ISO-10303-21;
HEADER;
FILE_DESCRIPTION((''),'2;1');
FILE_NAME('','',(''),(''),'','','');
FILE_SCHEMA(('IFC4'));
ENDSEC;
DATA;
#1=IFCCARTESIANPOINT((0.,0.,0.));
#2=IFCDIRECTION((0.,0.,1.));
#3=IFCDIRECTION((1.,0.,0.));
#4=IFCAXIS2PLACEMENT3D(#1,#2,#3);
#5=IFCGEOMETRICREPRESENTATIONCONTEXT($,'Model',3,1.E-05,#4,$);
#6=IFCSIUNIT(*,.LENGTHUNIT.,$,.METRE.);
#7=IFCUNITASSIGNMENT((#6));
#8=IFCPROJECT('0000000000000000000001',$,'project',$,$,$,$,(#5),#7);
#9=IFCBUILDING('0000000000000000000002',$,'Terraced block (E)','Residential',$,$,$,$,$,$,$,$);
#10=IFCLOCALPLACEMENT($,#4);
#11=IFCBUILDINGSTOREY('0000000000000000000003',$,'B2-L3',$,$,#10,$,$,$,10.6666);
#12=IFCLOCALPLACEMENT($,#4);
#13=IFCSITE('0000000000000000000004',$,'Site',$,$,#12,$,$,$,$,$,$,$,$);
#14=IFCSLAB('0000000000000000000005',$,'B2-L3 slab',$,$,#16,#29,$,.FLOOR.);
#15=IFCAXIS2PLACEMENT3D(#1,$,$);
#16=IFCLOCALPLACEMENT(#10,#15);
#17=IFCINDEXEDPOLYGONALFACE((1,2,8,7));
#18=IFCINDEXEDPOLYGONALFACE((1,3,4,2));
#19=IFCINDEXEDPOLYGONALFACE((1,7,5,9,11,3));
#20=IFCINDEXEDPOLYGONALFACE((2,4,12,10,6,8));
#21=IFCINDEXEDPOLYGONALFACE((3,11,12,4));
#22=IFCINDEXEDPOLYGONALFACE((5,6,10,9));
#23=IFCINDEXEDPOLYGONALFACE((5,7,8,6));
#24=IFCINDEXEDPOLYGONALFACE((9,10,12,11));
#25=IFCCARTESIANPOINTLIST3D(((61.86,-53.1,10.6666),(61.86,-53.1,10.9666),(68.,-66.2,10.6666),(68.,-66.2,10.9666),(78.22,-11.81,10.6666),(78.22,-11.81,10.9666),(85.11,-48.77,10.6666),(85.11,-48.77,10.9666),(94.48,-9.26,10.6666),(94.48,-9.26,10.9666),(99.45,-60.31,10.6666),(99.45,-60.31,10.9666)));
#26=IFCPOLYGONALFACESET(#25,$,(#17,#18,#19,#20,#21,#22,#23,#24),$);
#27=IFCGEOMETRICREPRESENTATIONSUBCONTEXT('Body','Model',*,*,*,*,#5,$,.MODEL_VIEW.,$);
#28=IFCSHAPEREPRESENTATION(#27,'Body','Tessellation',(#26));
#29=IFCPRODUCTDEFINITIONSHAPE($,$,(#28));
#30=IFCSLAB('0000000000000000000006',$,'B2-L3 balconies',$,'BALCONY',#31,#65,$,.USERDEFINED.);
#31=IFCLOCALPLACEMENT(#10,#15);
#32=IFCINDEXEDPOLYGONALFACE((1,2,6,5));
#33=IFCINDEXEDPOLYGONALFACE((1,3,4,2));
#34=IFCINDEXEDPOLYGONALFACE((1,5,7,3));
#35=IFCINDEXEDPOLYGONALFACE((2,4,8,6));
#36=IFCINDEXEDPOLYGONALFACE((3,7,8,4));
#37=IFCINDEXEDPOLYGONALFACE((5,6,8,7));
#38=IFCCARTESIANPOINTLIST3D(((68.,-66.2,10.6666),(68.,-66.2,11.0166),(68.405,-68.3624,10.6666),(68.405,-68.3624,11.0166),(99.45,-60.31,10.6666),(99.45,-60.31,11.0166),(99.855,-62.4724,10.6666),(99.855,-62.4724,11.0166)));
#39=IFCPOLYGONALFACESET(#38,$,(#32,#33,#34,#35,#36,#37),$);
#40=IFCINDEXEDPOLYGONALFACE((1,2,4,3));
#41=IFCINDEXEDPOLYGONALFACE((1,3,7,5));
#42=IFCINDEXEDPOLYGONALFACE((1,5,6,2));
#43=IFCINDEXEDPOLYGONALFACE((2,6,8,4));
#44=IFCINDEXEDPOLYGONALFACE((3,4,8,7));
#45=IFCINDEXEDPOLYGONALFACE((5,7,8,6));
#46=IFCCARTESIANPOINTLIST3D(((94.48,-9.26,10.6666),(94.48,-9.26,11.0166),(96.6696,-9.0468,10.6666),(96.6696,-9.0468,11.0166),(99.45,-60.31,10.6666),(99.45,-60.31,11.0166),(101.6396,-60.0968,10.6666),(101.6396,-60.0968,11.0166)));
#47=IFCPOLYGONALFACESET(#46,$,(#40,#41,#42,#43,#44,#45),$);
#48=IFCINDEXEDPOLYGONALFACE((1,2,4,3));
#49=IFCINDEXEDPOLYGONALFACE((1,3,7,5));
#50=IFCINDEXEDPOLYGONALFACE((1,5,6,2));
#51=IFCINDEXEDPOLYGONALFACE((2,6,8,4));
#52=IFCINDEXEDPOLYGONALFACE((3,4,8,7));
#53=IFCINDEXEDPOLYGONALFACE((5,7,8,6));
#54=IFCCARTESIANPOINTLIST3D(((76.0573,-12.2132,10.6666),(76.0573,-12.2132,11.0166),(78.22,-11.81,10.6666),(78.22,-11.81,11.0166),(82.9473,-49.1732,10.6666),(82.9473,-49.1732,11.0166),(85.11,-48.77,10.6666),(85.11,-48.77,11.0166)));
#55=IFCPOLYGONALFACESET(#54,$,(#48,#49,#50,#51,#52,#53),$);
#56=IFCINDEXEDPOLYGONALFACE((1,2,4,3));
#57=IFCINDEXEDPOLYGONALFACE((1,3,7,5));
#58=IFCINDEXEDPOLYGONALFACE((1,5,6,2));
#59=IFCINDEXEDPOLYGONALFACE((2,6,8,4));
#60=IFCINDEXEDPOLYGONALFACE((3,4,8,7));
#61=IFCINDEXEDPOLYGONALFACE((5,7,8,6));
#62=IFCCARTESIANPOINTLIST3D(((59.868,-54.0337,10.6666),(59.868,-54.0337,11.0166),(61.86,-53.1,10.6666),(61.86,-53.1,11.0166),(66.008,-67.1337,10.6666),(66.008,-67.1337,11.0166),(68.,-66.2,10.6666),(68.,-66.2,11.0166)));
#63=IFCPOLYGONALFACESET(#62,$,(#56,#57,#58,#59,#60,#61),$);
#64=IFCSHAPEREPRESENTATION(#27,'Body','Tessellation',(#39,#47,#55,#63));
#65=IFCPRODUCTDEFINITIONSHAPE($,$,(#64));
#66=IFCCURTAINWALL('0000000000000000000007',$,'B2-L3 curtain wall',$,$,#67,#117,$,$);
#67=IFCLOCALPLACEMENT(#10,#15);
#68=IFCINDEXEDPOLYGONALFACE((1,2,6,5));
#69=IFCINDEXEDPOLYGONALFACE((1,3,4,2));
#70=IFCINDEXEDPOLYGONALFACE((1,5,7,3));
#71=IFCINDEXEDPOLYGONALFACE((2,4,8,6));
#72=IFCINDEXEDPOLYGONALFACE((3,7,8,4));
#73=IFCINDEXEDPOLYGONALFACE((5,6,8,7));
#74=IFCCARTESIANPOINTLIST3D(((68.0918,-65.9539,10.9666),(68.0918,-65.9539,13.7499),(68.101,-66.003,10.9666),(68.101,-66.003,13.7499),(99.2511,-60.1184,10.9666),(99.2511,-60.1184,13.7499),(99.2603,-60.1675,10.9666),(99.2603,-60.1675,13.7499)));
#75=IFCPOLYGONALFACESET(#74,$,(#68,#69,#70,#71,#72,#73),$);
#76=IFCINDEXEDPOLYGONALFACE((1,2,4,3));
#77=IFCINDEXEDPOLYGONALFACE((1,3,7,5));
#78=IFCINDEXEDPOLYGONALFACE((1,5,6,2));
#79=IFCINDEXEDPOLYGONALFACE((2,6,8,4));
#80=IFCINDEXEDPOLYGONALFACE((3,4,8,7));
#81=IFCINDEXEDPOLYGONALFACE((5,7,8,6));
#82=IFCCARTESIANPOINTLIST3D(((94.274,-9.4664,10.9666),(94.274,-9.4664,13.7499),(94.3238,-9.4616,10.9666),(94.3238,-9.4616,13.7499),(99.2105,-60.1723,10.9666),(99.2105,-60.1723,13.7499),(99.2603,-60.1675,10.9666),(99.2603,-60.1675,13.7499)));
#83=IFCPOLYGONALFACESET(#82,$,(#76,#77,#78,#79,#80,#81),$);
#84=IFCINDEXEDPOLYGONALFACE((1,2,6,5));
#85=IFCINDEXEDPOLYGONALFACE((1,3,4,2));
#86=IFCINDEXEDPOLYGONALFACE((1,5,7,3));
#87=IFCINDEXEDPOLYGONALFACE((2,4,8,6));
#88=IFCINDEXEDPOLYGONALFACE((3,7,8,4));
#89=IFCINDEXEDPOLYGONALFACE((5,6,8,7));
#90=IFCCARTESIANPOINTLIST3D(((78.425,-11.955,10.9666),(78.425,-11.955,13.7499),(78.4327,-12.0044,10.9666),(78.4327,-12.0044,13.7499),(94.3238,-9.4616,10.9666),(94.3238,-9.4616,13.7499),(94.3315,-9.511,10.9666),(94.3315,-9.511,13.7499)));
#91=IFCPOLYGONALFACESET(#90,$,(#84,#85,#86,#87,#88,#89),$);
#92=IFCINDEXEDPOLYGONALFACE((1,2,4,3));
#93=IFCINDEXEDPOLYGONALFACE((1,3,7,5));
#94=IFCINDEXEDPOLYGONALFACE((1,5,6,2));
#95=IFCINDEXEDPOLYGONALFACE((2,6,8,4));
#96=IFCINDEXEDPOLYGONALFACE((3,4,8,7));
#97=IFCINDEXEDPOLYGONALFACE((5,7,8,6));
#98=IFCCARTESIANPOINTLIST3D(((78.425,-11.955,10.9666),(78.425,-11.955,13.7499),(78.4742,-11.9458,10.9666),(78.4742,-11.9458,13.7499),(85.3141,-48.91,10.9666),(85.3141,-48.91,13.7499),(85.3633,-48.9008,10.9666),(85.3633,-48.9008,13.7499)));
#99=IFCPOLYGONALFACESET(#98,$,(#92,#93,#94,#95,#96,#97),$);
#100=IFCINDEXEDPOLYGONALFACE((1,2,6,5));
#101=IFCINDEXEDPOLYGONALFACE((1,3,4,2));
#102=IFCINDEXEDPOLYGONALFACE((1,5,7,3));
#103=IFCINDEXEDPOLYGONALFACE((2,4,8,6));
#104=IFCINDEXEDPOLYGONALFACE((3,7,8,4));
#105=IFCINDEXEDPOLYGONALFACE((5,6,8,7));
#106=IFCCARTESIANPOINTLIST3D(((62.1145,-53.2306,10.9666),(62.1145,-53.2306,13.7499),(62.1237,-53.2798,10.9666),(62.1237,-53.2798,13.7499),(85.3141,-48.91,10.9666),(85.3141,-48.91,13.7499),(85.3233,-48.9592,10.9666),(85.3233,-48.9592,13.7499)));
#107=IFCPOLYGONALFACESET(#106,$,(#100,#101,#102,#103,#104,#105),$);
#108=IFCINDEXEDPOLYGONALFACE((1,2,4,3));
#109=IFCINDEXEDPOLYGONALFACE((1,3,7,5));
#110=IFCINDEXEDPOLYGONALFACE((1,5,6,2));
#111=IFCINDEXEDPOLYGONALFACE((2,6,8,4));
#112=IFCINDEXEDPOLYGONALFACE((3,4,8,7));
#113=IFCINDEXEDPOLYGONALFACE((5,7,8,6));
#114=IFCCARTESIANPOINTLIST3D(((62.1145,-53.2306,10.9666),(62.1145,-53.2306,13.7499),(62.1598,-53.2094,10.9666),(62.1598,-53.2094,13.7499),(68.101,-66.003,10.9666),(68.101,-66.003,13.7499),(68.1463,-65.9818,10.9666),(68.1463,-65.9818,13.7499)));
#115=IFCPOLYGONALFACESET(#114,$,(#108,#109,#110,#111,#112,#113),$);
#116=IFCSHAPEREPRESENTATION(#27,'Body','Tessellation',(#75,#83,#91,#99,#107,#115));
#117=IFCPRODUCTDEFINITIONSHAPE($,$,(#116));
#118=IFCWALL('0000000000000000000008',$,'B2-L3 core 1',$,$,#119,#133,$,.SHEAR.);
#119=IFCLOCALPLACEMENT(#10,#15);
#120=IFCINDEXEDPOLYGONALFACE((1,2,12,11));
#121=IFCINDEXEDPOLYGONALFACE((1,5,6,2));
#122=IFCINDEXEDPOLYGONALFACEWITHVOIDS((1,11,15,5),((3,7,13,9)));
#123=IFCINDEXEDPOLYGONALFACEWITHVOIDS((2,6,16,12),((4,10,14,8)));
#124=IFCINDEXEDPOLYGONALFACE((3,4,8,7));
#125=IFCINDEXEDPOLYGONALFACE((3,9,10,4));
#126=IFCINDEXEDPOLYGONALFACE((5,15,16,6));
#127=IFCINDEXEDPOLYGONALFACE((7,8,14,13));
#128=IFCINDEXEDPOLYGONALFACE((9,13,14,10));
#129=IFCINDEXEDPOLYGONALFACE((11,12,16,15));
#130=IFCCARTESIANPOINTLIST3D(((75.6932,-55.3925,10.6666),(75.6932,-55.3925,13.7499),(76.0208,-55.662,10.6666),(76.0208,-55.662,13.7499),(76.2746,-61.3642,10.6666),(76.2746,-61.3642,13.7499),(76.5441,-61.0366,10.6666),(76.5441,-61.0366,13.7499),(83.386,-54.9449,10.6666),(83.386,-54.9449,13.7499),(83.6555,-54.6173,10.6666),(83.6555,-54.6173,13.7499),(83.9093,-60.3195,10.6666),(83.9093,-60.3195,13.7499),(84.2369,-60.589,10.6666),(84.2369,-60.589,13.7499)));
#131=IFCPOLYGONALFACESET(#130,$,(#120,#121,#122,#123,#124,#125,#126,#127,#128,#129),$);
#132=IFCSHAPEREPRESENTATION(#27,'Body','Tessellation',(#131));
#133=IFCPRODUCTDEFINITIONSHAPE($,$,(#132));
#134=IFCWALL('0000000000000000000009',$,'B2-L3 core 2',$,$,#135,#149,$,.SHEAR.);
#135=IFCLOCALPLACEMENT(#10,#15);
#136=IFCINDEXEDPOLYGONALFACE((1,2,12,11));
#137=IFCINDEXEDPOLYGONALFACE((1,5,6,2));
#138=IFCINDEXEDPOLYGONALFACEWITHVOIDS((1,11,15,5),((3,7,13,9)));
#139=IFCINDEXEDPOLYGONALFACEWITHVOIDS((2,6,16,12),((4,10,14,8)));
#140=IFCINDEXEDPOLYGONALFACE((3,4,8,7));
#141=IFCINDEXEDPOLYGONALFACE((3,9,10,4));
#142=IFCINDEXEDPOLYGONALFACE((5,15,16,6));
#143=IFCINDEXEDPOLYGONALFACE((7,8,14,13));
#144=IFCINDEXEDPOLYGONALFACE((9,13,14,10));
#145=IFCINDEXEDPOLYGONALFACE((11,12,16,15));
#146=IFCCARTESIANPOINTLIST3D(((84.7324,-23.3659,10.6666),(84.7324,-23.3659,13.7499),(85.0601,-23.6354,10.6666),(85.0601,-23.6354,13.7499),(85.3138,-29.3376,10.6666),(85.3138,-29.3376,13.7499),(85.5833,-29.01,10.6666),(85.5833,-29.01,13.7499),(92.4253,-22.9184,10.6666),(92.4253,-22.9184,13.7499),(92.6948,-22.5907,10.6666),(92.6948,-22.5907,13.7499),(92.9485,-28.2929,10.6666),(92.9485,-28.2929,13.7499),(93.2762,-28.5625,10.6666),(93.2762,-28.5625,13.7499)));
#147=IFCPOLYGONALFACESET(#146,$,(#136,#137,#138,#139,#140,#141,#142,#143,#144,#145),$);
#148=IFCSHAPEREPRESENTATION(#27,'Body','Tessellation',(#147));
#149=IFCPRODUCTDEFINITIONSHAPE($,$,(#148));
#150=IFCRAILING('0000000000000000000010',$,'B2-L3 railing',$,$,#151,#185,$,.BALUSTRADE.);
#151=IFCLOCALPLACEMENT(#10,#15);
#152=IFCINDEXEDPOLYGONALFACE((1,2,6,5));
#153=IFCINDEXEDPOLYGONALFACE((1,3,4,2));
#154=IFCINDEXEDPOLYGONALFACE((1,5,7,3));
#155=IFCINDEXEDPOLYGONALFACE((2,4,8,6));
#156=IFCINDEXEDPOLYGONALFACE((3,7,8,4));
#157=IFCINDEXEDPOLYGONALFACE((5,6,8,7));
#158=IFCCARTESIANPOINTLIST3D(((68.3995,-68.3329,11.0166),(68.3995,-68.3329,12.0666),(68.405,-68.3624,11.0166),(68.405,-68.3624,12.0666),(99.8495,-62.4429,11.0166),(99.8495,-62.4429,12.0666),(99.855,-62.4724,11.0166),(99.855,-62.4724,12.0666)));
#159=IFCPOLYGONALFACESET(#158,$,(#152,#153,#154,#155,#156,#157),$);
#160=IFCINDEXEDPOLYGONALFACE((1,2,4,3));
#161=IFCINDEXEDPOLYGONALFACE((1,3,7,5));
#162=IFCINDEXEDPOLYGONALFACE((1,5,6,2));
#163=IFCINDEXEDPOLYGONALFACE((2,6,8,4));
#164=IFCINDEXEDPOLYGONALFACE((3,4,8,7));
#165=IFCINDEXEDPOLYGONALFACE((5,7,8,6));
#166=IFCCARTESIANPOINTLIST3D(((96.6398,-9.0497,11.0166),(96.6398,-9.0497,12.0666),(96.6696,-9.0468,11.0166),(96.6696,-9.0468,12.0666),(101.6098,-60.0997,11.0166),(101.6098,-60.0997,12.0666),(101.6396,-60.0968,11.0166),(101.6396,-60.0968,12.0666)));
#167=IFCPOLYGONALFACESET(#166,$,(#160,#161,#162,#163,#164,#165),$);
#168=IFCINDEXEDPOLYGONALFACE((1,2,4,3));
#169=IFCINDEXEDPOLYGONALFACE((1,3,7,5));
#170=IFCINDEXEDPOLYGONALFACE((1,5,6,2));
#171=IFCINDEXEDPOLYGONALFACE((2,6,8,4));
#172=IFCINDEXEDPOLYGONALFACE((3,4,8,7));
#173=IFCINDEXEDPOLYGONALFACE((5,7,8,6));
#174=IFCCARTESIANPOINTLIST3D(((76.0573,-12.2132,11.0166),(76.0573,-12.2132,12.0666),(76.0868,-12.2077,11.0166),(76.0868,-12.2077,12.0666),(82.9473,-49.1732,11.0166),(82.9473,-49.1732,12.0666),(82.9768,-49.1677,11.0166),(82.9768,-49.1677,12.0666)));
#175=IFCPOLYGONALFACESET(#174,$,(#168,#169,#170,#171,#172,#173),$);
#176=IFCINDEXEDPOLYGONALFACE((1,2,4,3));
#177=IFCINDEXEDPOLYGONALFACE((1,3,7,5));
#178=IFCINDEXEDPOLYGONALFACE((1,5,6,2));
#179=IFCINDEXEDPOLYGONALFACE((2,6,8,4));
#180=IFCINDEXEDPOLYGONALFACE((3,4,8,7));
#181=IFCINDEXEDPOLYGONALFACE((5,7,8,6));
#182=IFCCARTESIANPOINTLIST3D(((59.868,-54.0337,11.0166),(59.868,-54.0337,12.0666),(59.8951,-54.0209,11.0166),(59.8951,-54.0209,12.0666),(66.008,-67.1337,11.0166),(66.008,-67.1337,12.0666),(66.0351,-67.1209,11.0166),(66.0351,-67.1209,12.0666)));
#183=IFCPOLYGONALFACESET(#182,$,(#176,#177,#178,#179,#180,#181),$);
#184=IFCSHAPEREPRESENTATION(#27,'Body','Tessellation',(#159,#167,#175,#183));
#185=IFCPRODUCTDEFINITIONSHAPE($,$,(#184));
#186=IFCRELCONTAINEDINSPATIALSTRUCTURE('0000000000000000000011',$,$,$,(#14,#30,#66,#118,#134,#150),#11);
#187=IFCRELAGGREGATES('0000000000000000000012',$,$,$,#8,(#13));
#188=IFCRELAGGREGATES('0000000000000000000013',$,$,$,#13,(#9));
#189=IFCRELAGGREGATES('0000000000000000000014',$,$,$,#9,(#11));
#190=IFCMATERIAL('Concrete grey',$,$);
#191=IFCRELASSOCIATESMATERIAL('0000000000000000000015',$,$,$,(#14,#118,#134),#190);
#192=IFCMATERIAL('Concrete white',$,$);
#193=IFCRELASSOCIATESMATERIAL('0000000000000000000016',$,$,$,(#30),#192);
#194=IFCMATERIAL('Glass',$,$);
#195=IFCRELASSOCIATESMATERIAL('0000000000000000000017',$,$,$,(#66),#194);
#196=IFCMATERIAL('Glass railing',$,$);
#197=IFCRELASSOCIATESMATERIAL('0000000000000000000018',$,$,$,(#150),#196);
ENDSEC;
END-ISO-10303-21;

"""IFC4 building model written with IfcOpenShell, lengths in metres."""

from ifc_helpers import new_model, si_unit, frame, origin_with_axes, place, context, subcontext, project, spatial, polyline, outline, extrude, material, element, save


model = new_model("IFC4")

# Units and contexts
model_context = context("Model", 3, precision=1e-05, world=origin_with_axes())
body_context = subcontext(model_context, "Body", "Model", "MODEL_VIEW")
ifc_project = project(units=[si_unit("LENGTHUNIT", "METRE")], contexts=[model_context])

# Site, building, storey
site_placement = place(None, origin_with_axes())
site = spatial("IfcSite", under=ifc_project, at=site_placement, Name="Site")
building = spatial("IfcBuilding", under=site, Name="Terraced block (E)", Description="Residential")
storey_placement = place(None, origin_with_axes())
storey = spatial("IfcBuildingStorey", under=building, at=storey_placement, Name="B2-L3", Elevation=10.6666)

# Slabs
ifc_material_1 = material(Name="Concrete grey")
slab_1_placement = place(storey_placement, origin_with_axes())
element("IfcSlab", 1, at=slab_1_placement, inside=storey, material=ifc_material_1, Name="B2-L3 slab", PredefinedType="FLOOR", context=body_context, shape_type="SweptSolid", body=[
    extrude(outline(polyline([(68.0, -66.2), (99.45, -60.31), (94.48, -9.26), (78.22, -11.81), (85.11, -48.77), (61.86, -53.1), (68.0, -66.2)])), frame((0.0, 0.0, 10.6666), z_axis=(0.0, 0.0, 1.0), x_axis=(1.0, 0.0, 0.0)), (0.0, 0.0, 1.0), 0.3),
])
ifc_material_2 = material(Name="Concrete white")
slab_2_placement = place(storey_placement, origin_with_axes())
element("IfcSlab", 2, at=slab_2_placement, inside=storey, material=ifc_material_2, Name="B2-L3 balconies", ObjectType="BALCONY", PredefinedType="USERDEFINED", context=body_context, shape_type="SweptSolid", body=[
    extrude(outline(polyline([(68.0, -66.2), (99.45, -60.31), (99.855, -62.4724), (68.405, -68.3624), (68.0, -66.2)])), frame((0.0, 0.0, 10.6666), z_axis=(0.0, 0.0, 1.0), x_axis=(1.0, 0.0, 0.0)), (0.0, 0.0, 1.0), 0.35),
    extrude(outline(polyline([(99.45, -60.31), (94.48, -9.26), (96.6696, -9.0468), (101.6396, -60.0968), (99.45, -60.31)])), frame((0.0, 0.0, 10.6666), z_axis=(0.0, 0.0, 1.0), x_axis=(1.0, 0.0, 0.0)), (0.0, 0.0, 1.0), 0.35),
    extrude(outline(polyline([(78.22, -11.81), (85.11, -48.77), (82.9473, -49.1732), (76.0573, -12.2132), (78.22, -11.81)])), frame((0.0, 0.0, 10.6666), z_axis=(0.0, 0.0, 1.0), x_axis=(1.0, 0.0, 0.0)), (0.0, 0.0, 1.0), 0.35),
    extrude(outline(polyline([(61.86, -53.1), (68.0, -66.2), (66.008, -67.1337), (59.868, -54.0337), (61.86, -53.1)])), frame((0.0, 0.0, 10.6666), z_axis=(0.0, 0.0, 1.0), x_axis=(1.0, 0.0, 0.0)), (0.0, 0.0, 1.0), 0.35),
])

# Curtain wall
ifc_material_3 = material(Name="Glass")
curtain_wall_placement = place(storey_placement, origin_with_axes())
element("IfcCurtainWall", 3, at=curtain_wall_placement, inside=storey, material=ifc_material_3, Name="B2-L3 curtain wall", context=body_context, shape_type="SweptSolid", body=[
    extrude(outline(polyline([(68.101, -66.003), (99.2603, -60.1675), (99.2511, -60.1184), (68.0918, -65.9539), (68.101, -66.003)])), frame((0.0, 0.0, 10.9666), z_axis=(0.0, 0.0, 1.0), x_axis=(1.0, 0.0, 0.0)), (0.0, 0.0, 1.0), 2.7833),
    extrude(outline(polyline([(99.2603, -60.1675), (94.3238, -9.4616), (94.274, -9.4664), (99.2105, -60.1723), (99.2603, -60.1675)])), frame((0.0, 0.0, 10.9666), z_axis=(0.0, 0.0, 1.0), x_axis=(1.0, 0.0, 0.0)), (0.0, 0.0, 1.0), 2.7833),
    extrude(outline(polyline([(94.3238, -9.4616), (78.425, -11.955), (78.4327, -12.0044), (94.3315, -9.511), (94.3238, -9.4616)])), frame((0.0, 0.0, 10.9666), z_axis=(0.0, 0.0, 1.0), x_axis=(1.0, 0.0, 0.0)), (0.0, 0.0, 1.0), 2.7833),
    extrude(outline(polyline([(78.425, -11.955), (85.3141, -48.91), (85.3633, -48.9008), (78.4742, -11.9458), (78.425, -11.955)])), frame((0.0, 0.0, 10.9666), z_axis=(0.0, 0.0, 1.0), x_axis=(1.0, 0.0, 0.0)), (0.0, 0.0, 1.0), 2.7833),
    extrude(outline(polyline([(85.3141, -48.91), (62.1145, -53.2306), (62.1237, -53.2798), (85.3233, -48.9592), (85.3141, -48.91)])), frame((0.0, 0.0, 10.9666), z_axis=(0.0, 0.0, 1.0), x_axis=(1.0, 0.0, 0.0)), (0.0, 0.0, 1.0), 2.7833),
    extrude(outline(polyline([(62.1145, -53.2306), (68.101, -66.003), (68.1463, -65.9818), (62.1598, -53.2094), (62.1145, -53.2306)])), frame((0.0, 0.0, 10.9666), z_axis=(0.0, 0.0, 1.0), x_axis=(1.0, 0.0, 0.0)), (0.0, 0.0, 1.0), 2.7833),
])

# Walls
wall_1_placement = place(storey_placement, origin_with_axes())
element("IfcWall", 4, at=wall_1_placement, inside=storey, material=ifc_material_1, Name="B2-L3 core 1", PredefinedType="SHEAR", context=body_context, shape_type="SweptSolid", body=[
    extrude(outline(polyline([(84.2369, -60.589), (83.6555, -54.6173), (75.6932, -55.3925), (76.2746, -61.3642), (84.2369, -60.589)]), holes=[polyline([(83.9093, -60.3195), (83.386, -54.9449), (76.0208, -55.662), (76.5441, -61.0366), (83.9093, -60.3195)])]), frame((0.0, 0.0, 10.6666), z_axis=(0.0, 0.0, 1.0), x_axis=(1.0, 0.0, 0.0)), (0.0, 0.0, 1.0), 3.0833),
])
wall_2_placement = place(storey_placement, origin_with_axes())
element("IfcWall", 5, at=wall_2_placement, inside=storey, material=ifc_material_1, Name="B2-L3 core 2", PredefinedType="SHEAR", context=body_context, shape_type="SweptSolid", body=[
    extrude(outline(polyline([(93.2762, -28.5625), (92.6948, -22.5907), (84.7324, -23.3659), (85.3138, -29.3376), (93.2762, -28.5625)]), holes=[polyline([(92.9485, -28.2929), (92.4253, -22.9184), (85.0601, -23.6354), (85.5833, -29.01), (92.9485, -28.2929)])]), frame((0.0, 0.0, 10.6666), z_axis=(0.0, 0.0, 1.0), x_axis=(1.0, 0.0, 0.0)), (0.0, 0.0, 1.0), 3.0833),
])

# Railing
ifc_material_4 = material(Name="Glass railing")
railing_placement = place(storey_placement, origin_with_axes())
element("IfcRailing", 6, at=railing_placement, inside=storey, material=ifc_material_4, Name="B2-L3 railing", PredefinedType="BALUSTRADE", context=body_context, shape_type="SweptSolid", body=[
    extrude(outline(polyline([(68.405, -68.3624), (99.855, -62.4724), (99.8495, -62.4429), (68.3995, -68.3329), (68.405, -68.3624)])), frame((0.0, 0.0, 11.0166), z_axis=(0.0, 0.0, 1.0), x_axis=(1.0, 0.0, 0.0)), (0.0, 0.0, 1.0), 1.05),
    extrude(outline(polyline([(101.6396, -60.0968), (96.6696, -9.0468), (96.6398, -9.0497), (101.6098, -60.0997), (101.6396, -60.0968)])), frame((0.0, 0.0, 11.0166), z_axis=(0.0, 0.0, 1.0), x_axis=(1.0, 0.0, 0.0)), (0.0, 0.0, 1.0), 1.05),
    extrude(outline(polyline([(76.0573, -12.2132), (82.9473, -49.1732), (82.9768, -49.1677), (76.0868, -12.2077), (76.0573, -12.2132)])), frame((0.0, 0.0, 11.0166), z_axis=(0.0, 0.0, 1.0), x_axis=(1.0, 0.0, 0.0)), (0.0, 0.0, 1.0), 1.05),
    extrude(outline(polyline([(59.868, -54.0337), (66.008, -67.1337), (66.0351, -67.1209), (59.8951, -54.0209), (59.868, -54.0337)])), frame((0.0, 0.0, 11.0166), z_axis=(0.0, 0.0, 1.0), x_axis=(1.0, 0.0, 0.0)), (0.0, 0.0, 1.0), 1.05),
])

save(model, "model.ifc")
